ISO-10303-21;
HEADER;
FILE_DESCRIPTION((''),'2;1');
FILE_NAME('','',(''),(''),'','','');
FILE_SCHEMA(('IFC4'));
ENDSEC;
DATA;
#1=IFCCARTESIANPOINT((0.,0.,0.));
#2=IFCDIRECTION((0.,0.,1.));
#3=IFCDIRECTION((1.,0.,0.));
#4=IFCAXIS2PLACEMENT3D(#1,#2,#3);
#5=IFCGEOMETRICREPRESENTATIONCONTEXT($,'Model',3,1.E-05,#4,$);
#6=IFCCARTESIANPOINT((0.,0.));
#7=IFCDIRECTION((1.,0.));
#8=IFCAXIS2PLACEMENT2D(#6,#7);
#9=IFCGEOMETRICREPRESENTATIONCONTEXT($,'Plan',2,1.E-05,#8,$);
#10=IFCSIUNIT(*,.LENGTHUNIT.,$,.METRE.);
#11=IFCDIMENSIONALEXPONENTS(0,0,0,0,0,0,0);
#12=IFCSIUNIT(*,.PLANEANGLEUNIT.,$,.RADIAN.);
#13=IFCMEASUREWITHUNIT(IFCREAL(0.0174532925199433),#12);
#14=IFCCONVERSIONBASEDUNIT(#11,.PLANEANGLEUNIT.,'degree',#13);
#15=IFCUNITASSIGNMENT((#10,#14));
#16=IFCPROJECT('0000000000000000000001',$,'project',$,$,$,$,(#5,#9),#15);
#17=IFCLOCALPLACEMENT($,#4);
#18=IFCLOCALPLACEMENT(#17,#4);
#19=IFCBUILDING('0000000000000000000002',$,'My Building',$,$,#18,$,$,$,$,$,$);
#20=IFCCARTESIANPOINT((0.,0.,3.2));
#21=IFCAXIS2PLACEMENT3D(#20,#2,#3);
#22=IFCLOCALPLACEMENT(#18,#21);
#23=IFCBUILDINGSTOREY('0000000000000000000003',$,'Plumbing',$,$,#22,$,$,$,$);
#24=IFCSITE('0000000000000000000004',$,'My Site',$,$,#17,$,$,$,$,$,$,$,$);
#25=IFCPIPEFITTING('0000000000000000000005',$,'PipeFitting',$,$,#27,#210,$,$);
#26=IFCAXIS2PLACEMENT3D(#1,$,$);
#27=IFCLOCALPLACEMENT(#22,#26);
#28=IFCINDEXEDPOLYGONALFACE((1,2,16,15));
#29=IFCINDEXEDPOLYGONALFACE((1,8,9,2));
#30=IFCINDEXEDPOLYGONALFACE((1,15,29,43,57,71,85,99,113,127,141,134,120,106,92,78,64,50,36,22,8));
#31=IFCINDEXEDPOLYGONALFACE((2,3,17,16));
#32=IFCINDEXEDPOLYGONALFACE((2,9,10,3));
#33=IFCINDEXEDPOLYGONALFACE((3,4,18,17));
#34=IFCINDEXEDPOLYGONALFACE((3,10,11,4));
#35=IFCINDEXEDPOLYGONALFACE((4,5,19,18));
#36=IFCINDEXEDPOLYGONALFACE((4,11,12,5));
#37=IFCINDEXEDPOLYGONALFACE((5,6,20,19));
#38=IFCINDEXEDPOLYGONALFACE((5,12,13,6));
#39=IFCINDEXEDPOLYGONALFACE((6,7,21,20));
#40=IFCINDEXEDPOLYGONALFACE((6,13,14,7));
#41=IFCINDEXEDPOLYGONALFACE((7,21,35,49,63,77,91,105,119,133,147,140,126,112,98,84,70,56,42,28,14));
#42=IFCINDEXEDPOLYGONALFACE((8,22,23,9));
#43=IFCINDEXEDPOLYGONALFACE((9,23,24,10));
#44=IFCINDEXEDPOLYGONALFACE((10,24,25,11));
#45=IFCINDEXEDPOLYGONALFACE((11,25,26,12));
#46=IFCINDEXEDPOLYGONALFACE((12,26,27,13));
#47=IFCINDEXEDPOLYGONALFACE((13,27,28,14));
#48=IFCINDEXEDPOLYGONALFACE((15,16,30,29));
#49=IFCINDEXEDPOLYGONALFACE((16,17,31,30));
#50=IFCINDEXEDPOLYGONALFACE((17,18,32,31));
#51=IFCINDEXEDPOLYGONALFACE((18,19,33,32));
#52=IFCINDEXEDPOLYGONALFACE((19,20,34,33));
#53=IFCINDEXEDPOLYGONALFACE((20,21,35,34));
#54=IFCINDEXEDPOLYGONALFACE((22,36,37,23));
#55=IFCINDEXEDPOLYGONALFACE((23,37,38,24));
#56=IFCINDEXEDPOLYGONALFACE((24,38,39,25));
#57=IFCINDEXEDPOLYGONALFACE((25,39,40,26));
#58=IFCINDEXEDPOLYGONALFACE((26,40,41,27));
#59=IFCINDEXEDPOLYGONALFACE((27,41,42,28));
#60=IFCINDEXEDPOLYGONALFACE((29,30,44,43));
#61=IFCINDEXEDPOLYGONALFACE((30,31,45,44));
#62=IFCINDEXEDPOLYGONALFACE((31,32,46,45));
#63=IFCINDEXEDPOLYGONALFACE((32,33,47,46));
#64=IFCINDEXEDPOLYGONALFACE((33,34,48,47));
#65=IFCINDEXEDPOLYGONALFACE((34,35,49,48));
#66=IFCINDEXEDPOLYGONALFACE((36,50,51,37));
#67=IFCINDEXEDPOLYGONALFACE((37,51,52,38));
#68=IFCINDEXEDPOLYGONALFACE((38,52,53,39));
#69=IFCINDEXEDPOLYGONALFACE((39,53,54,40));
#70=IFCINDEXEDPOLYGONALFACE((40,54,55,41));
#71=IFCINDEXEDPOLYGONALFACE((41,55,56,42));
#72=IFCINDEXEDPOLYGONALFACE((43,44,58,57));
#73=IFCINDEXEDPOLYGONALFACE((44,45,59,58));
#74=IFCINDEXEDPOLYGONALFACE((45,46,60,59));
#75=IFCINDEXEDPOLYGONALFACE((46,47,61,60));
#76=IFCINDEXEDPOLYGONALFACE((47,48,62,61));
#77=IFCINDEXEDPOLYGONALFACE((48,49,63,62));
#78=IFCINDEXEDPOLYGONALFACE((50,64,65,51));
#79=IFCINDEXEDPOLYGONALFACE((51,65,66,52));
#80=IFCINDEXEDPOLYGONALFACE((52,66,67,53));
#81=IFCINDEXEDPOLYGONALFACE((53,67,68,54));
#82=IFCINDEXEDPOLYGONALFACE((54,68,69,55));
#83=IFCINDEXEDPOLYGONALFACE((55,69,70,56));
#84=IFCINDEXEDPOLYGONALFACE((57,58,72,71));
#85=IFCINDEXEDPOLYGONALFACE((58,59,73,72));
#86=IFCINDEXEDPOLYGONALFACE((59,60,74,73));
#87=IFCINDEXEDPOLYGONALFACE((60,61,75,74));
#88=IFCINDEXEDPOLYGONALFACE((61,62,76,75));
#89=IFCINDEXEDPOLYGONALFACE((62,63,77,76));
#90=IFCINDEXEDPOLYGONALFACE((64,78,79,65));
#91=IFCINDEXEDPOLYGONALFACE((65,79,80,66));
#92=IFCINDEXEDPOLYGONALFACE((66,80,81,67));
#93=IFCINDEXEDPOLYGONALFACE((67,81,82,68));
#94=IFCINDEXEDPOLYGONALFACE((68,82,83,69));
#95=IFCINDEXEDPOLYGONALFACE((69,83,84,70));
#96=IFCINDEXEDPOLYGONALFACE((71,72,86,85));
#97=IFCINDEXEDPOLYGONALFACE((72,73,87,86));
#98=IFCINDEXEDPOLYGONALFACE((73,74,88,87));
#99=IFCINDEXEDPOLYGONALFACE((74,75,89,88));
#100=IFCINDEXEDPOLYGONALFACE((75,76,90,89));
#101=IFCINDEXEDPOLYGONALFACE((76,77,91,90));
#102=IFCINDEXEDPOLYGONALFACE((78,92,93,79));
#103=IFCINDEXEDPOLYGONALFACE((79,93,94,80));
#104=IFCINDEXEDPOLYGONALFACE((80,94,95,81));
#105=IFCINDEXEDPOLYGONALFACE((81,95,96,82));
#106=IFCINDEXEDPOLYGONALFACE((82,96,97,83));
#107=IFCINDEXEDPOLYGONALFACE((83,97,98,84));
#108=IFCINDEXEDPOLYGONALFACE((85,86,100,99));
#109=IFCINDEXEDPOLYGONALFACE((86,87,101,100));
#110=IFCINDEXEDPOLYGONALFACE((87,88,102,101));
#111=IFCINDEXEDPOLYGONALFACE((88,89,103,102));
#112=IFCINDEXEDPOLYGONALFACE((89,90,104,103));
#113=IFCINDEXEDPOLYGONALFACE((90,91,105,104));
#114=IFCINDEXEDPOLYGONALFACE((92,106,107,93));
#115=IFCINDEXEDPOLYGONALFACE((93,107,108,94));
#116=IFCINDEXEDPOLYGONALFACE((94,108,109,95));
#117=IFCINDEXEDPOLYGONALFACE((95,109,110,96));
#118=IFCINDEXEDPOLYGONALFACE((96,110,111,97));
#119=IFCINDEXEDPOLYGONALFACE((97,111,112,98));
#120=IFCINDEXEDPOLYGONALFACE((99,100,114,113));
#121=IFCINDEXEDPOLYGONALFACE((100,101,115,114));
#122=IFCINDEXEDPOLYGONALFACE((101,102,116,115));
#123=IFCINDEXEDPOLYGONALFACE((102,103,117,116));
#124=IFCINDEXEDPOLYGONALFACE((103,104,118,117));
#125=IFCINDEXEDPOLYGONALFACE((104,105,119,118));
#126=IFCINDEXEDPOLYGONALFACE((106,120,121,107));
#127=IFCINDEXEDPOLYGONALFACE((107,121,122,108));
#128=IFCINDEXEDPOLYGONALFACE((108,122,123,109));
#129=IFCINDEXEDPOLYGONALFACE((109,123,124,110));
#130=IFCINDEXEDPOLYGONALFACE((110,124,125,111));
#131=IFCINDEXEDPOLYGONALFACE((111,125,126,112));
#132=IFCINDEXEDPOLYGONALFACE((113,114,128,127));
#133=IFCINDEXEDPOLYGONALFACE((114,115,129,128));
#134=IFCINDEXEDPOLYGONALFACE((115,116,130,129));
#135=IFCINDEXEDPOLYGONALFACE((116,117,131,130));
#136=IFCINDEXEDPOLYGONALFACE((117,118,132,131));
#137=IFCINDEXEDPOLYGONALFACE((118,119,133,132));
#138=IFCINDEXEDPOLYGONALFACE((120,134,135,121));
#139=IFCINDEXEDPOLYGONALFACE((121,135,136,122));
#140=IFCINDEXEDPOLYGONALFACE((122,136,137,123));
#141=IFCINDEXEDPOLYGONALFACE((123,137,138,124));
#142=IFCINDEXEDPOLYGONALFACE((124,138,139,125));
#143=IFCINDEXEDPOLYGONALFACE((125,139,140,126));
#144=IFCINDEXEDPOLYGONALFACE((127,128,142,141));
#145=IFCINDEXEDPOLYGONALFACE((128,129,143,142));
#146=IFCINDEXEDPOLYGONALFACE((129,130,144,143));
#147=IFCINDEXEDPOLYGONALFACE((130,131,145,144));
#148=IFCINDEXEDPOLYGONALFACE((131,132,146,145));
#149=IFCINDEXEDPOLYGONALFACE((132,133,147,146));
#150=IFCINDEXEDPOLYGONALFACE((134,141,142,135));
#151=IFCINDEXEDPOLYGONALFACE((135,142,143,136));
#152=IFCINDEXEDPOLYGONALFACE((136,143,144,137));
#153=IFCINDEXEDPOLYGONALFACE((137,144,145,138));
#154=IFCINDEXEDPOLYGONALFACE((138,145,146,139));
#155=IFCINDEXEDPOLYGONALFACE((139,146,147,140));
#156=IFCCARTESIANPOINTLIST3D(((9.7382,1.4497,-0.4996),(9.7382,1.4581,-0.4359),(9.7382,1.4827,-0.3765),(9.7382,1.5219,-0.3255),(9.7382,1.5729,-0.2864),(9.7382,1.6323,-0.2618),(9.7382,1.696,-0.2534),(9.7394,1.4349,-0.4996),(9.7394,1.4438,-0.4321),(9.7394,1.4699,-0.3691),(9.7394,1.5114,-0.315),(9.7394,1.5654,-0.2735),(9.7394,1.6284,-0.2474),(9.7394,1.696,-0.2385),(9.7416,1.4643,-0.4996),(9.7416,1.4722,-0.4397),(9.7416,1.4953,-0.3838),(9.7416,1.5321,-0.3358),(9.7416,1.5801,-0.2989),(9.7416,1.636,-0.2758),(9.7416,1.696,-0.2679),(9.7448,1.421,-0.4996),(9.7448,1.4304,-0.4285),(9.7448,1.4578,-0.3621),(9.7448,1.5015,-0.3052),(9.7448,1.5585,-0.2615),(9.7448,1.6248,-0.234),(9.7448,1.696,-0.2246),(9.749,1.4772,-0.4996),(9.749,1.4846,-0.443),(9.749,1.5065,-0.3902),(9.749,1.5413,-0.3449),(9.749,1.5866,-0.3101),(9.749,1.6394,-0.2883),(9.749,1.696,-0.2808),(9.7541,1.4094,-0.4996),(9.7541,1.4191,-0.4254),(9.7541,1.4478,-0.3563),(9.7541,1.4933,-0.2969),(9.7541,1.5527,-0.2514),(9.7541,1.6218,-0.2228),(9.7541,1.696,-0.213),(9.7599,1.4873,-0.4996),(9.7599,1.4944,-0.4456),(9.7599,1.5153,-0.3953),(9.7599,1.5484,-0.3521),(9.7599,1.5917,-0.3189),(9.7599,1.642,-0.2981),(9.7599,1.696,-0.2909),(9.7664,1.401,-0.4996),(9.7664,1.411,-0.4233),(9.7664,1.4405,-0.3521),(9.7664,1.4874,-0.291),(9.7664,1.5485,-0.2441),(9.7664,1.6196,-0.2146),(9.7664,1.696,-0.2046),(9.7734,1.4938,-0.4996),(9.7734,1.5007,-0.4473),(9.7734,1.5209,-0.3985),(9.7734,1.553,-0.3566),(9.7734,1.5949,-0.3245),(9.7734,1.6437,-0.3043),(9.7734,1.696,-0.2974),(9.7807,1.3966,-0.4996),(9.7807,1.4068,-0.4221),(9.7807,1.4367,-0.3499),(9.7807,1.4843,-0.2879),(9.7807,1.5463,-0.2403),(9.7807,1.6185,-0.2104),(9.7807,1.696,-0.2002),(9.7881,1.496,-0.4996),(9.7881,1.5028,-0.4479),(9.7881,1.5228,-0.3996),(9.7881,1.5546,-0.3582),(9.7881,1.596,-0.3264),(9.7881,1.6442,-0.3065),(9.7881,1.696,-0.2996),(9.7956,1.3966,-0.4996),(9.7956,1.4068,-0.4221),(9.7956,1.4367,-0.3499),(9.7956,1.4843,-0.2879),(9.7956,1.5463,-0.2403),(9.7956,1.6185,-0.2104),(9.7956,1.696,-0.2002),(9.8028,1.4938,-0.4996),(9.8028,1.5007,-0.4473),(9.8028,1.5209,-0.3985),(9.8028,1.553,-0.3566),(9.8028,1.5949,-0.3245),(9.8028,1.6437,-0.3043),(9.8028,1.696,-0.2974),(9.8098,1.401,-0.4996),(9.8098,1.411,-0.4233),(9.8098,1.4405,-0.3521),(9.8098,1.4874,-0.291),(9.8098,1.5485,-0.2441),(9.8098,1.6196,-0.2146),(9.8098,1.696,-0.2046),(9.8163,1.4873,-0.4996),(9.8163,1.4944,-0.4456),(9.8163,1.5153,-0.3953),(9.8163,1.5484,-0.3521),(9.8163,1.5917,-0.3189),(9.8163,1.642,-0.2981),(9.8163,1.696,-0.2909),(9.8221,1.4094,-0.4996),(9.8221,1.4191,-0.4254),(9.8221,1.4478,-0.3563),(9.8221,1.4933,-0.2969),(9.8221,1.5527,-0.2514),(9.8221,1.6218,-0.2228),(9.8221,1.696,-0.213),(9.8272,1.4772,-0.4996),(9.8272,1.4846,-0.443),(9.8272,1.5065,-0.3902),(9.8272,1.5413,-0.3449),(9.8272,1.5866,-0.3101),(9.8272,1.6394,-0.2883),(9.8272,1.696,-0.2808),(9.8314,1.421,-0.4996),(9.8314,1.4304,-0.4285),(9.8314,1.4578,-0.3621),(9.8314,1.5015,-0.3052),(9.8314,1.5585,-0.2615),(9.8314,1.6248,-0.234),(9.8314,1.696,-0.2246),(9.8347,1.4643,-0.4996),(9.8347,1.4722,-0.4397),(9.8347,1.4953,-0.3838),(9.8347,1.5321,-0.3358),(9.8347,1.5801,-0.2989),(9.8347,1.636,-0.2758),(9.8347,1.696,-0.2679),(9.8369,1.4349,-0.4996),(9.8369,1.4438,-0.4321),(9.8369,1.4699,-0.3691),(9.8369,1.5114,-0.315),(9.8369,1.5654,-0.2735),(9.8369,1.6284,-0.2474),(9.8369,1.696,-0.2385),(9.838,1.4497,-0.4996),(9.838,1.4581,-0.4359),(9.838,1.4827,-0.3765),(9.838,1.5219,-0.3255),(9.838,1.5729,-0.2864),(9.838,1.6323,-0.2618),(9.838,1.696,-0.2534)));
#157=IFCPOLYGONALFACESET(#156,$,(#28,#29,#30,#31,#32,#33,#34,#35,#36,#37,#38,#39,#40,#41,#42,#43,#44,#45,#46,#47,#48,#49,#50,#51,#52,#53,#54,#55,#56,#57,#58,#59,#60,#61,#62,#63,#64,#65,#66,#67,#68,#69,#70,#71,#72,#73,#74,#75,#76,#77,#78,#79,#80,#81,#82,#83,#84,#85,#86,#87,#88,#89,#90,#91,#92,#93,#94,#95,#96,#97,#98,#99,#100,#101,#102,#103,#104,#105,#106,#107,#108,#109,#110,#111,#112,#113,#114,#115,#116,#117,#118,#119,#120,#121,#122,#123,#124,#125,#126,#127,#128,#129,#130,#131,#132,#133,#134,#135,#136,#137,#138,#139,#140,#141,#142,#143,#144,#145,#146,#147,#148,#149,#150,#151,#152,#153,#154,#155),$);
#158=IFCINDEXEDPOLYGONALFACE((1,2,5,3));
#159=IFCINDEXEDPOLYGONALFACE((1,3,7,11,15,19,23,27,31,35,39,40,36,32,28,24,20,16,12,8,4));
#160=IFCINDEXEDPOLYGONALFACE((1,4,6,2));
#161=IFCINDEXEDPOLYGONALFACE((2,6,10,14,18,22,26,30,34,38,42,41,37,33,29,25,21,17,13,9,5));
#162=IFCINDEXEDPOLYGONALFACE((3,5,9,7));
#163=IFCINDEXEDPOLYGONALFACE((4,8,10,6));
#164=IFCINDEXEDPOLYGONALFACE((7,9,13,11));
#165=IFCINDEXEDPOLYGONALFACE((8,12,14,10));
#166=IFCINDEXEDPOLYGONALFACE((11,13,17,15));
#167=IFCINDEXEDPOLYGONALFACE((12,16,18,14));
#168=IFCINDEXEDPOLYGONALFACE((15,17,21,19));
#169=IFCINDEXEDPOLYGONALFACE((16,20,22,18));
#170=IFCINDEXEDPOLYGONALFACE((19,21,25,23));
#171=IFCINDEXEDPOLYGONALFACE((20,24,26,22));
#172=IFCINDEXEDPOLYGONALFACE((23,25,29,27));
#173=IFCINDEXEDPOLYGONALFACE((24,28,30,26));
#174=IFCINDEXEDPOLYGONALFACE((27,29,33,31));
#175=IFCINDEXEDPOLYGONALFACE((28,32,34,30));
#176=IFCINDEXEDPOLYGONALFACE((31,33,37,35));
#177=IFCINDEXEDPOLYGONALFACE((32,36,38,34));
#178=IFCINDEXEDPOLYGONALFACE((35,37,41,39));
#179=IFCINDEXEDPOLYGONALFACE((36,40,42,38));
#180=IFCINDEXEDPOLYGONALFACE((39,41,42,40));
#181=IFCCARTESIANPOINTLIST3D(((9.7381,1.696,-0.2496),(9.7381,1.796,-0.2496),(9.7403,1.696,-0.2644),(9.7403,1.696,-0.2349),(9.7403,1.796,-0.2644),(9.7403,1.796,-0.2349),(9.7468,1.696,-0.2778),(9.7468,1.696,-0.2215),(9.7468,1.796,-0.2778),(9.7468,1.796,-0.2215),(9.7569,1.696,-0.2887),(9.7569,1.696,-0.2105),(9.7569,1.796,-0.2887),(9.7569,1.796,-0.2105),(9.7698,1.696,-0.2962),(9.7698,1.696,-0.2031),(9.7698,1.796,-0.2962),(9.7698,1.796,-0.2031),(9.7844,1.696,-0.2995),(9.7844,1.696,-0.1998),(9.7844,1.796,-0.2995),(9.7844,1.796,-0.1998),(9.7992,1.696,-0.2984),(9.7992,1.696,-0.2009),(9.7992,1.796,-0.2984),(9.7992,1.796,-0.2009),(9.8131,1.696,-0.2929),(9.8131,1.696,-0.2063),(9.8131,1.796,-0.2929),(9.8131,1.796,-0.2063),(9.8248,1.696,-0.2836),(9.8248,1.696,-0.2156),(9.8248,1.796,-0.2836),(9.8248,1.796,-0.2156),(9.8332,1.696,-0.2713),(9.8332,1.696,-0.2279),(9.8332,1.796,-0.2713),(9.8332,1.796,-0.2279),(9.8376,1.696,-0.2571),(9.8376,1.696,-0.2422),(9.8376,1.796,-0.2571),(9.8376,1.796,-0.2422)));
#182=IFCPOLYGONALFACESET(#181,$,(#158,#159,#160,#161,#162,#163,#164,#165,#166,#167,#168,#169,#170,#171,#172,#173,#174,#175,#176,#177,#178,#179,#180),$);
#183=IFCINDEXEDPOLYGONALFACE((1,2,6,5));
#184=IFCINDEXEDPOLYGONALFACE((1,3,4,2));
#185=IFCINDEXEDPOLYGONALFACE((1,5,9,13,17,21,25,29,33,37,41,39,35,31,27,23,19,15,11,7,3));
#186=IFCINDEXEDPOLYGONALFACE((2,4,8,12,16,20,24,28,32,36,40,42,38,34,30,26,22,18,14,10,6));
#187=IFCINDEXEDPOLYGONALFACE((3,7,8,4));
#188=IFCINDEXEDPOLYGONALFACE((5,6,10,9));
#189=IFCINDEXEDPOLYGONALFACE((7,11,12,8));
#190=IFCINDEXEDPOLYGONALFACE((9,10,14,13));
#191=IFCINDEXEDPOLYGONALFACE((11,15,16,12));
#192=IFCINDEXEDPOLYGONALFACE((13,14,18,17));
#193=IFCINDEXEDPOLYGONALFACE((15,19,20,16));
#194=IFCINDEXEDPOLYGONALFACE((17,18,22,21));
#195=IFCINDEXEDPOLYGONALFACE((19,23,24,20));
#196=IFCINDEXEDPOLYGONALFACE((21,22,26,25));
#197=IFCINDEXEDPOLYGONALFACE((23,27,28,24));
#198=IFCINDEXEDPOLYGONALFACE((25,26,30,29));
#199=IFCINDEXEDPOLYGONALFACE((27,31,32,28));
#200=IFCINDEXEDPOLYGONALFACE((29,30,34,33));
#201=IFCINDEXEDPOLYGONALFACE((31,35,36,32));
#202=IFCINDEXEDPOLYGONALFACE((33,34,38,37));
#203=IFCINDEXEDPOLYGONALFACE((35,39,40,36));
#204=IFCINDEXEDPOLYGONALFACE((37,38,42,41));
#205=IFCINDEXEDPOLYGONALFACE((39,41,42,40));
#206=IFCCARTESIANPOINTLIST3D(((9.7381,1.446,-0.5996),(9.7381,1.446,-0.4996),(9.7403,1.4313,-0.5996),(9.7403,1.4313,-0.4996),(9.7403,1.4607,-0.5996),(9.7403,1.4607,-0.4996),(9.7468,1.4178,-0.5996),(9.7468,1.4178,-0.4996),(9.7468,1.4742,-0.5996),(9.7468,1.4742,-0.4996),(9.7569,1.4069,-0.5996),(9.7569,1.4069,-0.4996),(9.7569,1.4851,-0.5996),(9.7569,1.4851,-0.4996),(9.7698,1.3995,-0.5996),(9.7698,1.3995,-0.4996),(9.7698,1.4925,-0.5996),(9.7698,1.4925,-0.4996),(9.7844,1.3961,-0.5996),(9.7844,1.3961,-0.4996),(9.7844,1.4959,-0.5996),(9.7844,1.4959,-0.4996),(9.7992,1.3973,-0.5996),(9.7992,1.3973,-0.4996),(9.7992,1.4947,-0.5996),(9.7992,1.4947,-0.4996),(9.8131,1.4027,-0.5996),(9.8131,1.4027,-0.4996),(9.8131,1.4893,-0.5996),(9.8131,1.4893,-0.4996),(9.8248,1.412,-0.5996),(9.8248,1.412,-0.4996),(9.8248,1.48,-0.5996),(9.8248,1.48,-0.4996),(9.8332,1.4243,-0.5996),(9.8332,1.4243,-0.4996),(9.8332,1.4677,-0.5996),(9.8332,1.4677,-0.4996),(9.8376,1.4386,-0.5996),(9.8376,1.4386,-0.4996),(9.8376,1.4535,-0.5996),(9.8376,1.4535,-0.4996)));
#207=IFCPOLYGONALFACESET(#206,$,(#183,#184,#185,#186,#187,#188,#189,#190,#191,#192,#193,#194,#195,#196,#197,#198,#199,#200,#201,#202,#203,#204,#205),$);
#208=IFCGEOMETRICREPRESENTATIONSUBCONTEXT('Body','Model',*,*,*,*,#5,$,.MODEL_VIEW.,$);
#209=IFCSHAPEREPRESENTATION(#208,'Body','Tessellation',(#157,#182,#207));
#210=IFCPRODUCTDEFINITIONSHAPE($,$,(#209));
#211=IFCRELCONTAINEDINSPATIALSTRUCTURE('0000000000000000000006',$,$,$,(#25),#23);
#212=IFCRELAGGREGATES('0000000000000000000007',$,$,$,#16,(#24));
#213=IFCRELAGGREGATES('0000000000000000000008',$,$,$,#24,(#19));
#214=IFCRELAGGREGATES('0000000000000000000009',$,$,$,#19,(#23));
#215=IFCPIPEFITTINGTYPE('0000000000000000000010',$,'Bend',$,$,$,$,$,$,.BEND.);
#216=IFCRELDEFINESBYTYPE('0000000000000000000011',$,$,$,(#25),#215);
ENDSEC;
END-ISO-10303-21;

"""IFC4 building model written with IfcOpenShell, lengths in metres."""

from ifc_helpers import new_model, entity, si_unit, converted_unit, frame, origin_with_axes, origin_2d_with_axis, place, context, subcontext, project, spatial, circle, extrude, source, transform, mapped, type_object, type_shapes, element, save


model = new_model("IFC4")

# Units and contexts
model_context = context("Model", 3, precision=1e-05, world=origin_with_axes())
plan_context = context("Plan", 2, precision=1e-05, world=origin_2d_with_axis())
body_context = subcontext(model_context, "Body", "Model", "MODEL_VIEW")
ifc_project = project(units=[si_unit("LENGTHUNIT", "METRE"), converted_unit("PLANEANGLEUNIT", "degree", entity("IfcReal", 0.0174532925199433), si_unit("PLANEANGLEUNIT", "RADIAN"), dimensions=[0, 0, 0, 0, 0, 0, 0])], contexts=[model_context, plan_context])

# Site, building, storey
site_placement = place(None, origin_with_axes())
site = spatial("IfcSite", under=ifc_project, at=site_placement, Name="My Site")
building_placement = place(site_placement, origin_with_axes())
building = spatial("IfcBuilding", under=site, at=building_placement, Name="My Building")
storey_placement = place(building_placement, frame((0.0, 0.0, 3.2), z_axis=(0.0, 0.0, 1.0), x_axis=(1.0, 0.0, 0.0)))
storey = spatial("IfcBuildingStorey", under=building, at=storey_placement, Name="Plumbing")

# Pipe fitting
pipe_fitting_type = type_object("IfcPipeFittingType", Name="Bend", PredefinedType="BEND")
shared_shape = source(origin_with_axes(), body_context, "Body", "SolidModel", [
    entity("IfcSweptDiskSolid", entity("IfcIndexedPolyCurve", entity("IfcCartesianPointList3D", [[0.0, 0.0, -0.1], [0.0, -0.0732, -0.2768], [0.0, -0.25, -0.35]]), [entity("IfcArcIndex", [1, 2, 3])]), 0.05),
    extrude(circle(Radius=0.05), origin_with_axes(), (0.0, 0.0, -1.0), 0.1),
    extrude(circle(Radius=0.05), frame((0.0, -0.25, -0.35), z_axis=(0.0, -1.0, 0.0), x_axis=(1.0, 0.0, 0.0)), (0.0, 0.0, 1.0), 0.1),
])
type_shapes(pipe_fitting_type, [shared_shape])
for number, where, z_axis, x_axis, name in (
    (1, (9.7881, 1.796, -0.2496), (0.0, 1.0, 0.0), (-1.0, 0.0, 0.0), "PipeFitting"),
):
    element("IfcPipeFitting", number, at=place(storey_placement, frame(where, z_axis=z_axis, x_axis=x_axis)), inside=storey, type_object=pipe_fitting_type, Name=name, context=body_context, shape_type="MappedRepresentation", body=[
        mapped(shared_shape, transform((0.0, 0.0, 0.0), x_axis=(1.0, 0.0, 0.0), y_axis=(0.0, 1.0, 0.0), z_axis=(0.0, 0.0, 1.0), scale=1.0)),
    ])

save(model, "model.ifc")
